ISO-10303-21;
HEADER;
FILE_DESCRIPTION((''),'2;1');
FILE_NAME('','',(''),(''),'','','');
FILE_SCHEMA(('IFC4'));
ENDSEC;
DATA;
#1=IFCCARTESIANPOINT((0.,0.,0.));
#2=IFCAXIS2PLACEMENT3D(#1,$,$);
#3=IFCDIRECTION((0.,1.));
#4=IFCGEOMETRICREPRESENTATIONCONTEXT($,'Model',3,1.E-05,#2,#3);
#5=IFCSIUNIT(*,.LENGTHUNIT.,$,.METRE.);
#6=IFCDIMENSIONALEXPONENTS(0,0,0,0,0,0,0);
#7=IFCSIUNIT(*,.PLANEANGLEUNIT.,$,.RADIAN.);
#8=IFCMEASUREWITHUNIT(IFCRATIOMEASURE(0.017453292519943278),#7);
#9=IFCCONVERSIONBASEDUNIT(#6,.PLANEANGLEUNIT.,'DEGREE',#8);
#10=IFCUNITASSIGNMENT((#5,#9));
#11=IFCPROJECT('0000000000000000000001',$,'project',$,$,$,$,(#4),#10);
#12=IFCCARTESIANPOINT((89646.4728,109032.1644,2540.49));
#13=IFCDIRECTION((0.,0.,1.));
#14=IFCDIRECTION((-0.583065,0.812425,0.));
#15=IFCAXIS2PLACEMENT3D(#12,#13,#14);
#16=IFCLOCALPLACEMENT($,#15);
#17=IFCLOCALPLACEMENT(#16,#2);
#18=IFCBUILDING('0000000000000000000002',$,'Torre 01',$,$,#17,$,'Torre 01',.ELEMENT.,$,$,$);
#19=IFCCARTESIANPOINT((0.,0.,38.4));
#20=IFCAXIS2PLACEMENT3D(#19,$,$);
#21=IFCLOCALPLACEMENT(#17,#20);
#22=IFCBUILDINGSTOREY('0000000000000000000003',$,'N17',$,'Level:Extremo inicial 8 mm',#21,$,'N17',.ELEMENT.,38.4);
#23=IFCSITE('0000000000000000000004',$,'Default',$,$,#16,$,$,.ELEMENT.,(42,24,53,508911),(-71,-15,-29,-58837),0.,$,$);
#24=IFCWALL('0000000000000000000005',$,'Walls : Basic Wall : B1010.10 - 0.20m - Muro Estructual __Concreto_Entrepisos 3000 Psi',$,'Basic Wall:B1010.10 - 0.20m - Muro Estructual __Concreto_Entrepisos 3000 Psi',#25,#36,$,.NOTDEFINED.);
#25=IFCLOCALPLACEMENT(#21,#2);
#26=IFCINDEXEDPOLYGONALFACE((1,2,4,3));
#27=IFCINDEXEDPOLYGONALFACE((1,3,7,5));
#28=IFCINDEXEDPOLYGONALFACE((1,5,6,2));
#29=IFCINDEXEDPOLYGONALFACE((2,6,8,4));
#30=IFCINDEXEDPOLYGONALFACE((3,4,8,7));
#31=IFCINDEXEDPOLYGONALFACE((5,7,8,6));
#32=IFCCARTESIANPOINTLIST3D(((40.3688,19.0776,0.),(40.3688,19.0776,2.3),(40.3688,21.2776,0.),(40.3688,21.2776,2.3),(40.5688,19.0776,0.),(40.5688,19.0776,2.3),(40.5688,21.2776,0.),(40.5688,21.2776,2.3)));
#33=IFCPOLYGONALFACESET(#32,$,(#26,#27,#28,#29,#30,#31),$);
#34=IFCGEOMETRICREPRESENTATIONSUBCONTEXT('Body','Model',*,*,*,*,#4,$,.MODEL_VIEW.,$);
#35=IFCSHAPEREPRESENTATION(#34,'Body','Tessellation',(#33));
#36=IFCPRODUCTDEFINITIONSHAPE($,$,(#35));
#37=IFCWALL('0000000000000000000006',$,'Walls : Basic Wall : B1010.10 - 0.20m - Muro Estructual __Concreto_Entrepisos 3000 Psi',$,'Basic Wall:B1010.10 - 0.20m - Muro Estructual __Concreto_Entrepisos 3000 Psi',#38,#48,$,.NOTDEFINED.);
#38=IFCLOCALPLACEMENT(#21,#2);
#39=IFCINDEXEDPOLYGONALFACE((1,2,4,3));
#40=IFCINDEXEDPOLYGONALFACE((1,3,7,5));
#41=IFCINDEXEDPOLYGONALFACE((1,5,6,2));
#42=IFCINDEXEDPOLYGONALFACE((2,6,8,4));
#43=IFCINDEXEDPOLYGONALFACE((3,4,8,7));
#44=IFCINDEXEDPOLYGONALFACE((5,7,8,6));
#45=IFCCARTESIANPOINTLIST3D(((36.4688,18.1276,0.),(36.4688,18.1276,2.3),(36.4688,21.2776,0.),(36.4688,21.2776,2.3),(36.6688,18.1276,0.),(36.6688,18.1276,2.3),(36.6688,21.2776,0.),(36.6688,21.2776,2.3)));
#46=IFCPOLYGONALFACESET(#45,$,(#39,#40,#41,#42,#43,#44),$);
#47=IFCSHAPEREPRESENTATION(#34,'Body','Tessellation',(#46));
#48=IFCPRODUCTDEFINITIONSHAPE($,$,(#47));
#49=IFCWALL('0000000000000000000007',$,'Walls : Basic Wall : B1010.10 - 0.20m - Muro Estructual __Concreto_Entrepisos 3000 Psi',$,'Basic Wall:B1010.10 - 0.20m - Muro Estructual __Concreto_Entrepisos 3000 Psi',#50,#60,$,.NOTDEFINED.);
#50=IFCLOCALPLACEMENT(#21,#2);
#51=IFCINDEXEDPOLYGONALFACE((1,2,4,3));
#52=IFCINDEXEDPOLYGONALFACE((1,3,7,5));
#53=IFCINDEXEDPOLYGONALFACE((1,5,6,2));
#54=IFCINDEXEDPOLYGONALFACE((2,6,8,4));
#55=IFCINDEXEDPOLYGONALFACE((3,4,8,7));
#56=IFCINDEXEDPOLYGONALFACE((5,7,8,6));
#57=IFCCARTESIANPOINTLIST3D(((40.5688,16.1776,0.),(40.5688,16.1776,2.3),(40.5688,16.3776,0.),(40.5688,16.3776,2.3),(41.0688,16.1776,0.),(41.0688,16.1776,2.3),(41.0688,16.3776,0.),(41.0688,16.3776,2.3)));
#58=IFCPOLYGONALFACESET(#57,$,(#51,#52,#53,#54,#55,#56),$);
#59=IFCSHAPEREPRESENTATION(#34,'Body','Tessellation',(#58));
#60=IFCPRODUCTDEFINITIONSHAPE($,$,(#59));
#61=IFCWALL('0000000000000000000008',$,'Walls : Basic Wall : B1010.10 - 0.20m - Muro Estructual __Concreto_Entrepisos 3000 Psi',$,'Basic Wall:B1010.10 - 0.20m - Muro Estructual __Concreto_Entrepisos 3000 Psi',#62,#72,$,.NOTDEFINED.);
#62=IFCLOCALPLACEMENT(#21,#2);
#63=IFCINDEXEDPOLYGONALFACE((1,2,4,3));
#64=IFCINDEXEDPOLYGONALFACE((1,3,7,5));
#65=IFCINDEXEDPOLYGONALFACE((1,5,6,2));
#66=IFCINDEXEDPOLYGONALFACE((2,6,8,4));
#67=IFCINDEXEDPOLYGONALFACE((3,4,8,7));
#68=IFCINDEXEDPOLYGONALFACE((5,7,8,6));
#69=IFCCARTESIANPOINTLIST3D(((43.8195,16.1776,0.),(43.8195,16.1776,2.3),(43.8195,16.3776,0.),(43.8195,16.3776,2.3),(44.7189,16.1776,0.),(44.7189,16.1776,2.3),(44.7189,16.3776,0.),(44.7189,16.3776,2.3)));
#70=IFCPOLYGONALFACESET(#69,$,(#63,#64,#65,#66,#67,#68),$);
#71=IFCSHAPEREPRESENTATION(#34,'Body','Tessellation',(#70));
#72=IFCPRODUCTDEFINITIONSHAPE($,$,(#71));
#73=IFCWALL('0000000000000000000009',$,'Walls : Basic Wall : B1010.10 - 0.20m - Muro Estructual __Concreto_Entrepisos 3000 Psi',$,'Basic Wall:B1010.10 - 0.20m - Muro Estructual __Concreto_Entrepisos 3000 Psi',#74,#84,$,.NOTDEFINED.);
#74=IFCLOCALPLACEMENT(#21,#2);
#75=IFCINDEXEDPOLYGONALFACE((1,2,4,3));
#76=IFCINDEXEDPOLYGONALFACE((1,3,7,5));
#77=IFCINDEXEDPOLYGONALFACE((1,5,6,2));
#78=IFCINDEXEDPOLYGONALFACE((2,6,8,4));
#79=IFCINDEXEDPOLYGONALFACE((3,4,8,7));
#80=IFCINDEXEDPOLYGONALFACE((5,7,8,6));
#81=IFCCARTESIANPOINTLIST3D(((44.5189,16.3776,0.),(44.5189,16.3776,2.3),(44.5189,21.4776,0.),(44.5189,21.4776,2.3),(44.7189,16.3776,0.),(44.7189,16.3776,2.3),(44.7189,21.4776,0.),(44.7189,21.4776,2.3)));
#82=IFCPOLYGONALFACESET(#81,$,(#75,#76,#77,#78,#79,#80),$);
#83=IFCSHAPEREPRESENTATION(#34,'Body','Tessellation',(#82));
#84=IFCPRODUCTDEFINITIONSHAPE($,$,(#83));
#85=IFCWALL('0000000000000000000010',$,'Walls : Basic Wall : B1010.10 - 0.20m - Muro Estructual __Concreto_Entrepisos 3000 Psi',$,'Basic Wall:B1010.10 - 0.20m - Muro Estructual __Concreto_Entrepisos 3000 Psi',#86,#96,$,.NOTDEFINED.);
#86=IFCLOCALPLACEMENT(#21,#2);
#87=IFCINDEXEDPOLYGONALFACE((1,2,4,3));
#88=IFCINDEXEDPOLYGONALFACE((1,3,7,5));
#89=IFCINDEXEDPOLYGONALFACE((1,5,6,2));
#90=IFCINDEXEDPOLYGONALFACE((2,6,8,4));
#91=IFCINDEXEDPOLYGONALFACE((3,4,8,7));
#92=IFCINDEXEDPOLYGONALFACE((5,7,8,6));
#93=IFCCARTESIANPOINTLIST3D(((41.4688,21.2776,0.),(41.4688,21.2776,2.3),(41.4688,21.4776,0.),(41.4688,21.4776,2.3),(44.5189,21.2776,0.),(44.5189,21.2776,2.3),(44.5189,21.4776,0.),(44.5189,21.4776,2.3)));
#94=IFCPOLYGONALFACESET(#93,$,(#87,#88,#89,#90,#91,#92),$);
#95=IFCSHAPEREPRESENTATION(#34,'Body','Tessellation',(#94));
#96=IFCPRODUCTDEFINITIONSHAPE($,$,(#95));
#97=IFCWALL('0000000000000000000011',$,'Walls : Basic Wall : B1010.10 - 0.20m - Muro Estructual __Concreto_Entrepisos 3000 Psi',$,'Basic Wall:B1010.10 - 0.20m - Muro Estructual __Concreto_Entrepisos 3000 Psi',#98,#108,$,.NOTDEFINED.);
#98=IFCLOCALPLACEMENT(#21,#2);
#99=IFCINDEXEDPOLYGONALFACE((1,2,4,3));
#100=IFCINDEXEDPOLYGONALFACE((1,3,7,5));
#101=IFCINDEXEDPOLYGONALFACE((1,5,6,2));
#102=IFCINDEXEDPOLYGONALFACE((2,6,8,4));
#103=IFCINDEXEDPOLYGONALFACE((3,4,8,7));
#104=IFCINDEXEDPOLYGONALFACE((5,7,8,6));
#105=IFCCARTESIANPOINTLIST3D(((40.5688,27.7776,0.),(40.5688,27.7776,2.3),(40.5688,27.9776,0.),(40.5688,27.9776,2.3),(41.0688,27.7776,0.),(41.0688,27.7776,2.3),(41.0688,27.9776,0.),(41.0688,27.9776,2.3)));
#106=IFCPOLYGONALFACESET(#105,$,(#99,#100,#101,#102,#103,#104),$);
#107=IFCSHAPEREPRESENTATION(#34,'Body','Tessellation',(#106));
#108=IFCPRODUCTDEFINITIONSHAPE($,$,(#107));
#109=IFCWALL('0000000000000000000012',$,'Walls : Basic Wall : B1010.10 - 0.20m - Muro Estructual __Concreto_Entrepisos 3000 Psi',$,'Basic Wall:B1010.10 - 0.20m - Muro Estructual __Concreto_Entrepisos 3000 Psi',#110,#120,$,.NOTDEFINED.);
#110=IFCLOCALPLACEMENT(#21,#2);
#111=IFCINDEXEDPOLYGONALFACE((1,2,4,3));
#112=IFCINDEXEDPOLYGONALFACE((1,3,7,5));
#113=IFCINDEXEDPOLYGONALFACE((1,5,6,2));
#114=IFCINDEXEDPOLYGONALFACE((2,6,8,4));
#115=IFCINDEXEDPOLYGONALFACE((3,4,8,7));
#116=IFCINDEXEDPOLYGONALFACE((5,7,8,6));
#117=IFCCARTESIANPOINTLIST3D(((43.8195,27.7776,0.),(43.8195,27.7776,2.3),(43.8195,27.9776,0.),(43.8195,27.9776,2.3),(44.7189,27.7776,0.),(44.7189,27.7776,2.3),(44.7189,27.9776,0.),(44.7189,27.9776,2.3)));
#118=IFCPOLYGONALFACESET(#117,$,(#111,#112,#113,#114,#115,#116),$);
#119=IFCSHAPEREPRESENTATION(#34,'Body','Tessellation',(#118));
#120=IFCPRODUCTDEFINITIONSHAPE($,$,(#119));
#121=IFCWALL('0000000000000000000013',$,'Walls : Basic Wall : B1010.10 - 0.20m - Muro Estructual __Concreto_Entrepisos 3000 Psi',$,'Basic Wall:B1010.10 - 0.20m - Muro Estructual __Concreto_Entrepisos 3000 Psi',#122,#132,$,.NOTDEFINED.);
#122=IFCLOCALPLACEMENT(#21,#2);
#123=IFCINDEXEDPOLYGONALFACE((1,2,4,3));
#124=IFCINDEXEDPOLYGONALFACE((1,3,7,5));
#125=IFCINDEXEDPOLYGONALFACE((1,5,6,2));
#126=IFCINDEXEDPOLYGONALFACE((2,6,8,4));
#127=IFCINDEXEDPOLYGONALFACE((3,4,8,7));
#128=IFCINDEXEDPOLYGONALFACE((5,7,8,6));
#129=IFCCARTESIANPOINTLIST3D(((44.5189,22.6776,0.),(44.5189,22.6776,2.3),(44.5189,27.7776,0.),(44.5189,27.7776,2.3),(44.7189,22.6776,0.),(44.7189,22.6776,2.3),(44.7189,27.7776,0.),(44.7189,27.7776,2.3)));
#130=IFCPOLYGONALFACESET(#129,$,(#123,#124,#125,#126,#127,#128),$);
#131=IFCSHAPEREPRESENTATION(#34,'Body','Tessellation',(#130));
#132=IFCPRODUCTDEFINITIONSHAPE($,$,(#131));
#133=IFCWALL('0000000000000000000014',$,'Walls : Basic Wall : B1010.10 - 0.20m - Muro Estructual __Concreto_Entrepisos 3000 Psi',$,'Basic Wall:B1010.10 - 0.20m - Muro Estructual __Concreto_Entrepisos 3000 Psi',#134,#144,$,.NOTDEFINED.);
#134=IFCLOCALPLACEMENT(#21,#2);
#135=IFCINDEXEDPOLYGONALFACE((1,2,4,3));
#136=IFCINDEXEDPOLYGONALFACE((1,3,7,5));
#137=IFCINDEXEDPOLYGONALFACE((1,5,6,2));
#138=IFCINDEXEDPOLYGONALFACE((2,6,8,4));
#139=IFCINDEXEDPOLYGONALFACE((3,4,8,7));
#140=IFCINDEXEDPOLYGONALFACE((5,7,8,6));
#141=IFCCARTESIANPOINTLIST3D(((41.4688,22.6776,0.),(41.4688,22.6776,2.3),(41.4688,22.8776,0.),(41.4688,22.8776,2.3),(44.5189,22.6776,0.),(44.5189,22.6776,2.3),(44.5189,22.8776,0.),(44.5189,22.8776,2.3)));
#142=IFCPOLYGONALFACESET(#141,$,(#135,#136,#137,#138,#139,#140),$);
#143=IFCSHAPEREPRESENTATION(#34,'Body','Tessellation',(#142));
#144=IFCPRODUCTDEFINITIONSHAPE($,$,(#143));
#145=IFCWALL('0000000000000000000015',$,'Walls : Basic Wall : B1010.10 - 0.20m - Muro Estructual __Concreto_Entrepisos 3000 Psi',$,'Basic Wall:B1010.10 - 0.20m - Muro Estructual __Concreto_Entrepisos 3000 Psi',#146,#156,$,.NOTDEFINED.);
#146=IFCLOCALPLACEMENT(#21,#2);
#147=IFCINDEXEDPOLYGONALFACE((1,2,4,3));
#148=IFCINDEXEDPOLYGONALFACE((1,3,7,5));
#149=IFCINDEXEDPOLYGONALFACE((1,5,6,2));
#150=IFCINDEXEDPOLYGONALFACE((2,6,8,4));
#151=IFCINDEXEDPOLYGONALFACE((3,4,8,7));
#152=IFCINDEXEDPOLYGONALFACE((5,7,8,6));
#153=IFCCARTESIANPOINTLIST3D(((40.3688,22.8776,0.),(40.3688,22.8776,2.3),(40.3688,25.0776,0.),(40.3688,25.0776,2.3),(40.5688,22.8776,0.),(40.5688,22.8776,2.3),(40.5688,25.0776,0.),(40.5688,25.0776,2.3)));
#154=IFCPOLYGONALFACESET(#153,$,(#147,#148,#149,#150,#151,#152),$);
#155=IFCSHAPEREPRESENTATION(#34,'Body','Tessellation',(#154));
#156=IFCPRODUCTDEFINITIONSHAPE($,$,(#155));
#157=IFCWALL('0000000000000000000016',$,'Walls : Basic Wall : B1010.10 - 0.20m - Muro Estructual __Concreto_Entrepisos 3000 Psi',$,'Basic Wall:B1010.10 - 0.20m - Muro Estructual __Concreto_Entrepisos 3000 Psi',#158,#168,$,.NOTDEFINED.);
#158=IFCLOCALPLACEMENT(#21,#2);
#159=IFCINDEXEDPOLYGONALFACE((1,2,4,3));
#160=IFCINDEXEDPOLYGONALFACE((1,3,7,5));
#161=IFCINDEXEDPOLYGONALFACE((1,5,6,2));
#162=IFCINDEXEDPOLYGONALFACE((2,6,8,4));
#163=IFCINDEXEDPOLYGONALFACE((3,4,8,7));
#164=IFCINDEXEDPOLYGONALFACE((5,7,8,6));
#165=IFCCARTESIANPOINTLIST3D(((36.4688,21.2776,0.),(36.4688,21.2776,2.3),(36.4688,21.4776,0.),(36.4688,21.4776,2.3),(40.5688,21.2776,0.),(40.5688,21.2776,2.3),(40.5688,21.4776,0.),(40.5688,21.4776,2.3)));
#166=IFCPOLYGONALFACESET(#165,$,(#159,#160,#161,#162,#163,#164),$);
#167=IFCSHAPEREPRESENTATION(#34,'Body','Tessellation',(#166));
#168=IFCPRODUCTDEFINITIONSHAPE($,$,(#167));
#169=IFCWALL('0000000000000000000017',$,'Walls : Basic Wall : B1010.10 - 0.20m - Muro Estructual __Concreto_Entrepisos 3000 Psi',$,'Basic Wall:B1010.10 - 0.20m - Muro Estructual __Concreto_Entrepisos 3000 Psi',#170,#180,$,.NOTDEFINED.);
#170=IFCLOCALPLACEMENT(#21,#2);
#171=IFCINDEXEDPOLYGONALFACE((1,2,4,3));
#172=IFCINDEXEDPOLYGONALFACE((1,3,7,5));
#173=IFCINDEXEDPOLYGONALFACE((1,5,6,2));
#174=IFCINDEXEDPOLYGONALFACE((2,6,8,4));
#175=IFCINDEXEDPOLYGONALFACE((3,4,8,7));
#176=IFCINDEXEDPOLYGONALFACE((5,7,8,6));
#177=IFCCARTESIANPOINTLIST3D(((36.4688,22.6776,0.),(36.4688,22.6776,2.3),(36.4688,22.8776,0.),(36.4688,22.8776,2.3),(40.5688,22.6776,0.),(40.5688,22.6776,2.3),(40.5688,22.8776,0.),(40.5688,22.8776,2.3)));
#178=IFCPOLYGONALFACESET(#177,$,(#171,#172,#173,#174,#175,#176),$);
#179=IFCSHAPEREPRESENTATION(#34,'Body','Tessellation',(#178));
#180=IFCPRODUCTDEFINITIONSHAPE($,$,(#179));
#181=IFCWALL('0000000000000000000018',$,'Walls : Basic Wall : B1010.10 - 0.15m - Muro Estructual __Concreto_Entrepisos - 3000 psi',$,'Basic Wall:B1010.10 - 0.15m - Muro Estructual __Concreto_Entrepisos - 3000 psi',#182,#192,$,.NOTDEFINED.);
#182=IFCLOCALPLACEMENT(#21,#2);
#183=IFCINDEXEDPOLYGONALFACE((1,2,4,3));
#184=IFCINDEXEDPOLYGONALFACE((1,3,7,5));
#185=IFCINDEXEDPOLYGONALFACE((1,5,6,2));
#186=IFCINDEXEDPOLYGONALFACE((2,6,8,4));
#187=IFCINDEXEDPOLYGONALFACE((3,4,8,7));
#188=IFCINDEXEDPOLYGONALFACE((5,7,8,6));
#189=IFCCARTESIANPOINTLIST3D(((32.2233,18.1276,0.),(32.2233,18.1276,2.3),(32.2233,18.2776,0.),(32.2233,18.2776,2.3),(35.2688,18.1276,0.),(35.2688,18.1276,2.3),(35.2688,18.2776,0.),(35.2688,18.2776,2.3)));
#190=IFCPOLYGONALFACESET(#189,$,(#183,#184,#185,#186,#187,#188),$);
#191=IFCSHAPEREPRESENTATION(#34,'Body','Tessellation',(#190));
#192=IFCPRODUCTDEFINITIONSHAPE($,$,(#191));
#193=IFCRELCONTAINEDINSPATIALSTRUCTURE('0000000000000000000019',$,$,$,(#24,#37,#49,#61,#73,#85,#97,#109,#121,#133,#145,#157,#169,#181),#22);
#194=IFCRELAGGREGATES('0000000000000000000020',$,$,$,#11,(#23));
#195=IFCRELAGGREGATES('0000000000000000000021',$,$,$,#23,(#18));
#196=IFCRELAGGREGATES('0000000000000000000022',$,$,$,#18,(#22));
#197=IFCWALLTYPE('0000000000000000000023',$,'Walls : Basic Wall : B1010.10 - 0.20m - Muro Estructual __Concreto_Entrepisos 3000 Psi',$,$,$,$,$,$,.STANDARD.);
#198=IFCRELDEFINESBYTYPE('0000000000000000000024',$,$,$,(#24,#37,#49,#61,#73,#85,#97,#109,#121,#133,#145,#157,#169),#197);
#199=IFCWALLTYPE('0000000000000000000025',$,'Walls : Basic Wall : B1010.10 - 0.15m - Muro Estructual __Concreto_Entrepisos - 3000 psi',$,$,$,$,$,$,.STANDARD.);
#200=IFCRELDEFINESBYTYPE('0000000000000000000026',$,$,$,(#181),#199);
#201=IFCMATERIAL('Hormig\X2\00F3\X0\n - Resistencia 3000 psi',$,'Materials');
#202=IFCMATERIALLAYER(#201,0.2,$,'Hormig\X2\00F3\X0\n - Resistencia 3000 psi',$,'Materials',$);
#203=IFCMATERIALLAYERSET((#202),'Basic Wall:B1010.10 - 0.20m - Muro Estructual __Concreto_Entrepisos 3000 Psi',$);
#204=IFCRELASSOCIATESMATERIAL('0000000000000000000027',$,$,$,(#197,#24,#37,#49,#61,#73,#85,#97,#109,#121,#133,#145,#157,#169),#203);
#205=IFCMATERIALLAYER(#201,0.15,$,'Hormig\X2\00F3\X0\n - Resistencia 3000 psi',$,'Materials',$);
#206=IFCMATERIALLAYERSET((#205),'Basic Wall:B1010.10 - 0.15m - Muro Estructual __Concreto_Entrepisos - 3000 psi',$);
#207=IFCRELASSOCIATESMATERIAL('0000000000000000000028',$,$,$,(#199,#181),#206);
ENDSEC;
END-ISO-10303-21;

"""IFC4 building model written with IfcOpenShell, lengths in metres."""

from ifc_helpers import new_model, entity, si_unit, converted_unit, direction, frame, frame_2d, origin, place, context, subcontext, project, spatial, rectangle, extrude, material, layer, layer_set, layer_usage, type_object, element, save


model = new_model("IFC4")

# Units and contexts
model_context = context("Model", 3, precision=1e-05, world=origin(), true_north=direction((0.0, 1.0)))
body_context = subcontext(model_context, "Body", "Model", "MODEL_VIEW")
ifc_project = project(units=[si_unit("LENGTHUNIT", "METRE"), converted_unit("PLANEANGLEUNIT", "DEGREE", entity("IfcRatioMeasure", 0.017453292519943278), si_unit("PLANEANGLEUNIT", "RADIAN"), dimensions=[0, 0, 0, 0, 0, 0, 0])], contexts=[model_context])

# Site, building, storey
site_placement = place(None, frame((89646.4728, 109032.1644, 2540.49), z_axis=(0.0, 0.0, 1.0), x_axis=(-0.583065, 0.812425, 0.0)))
site = spatial("IfcSite", under=ifc_project, at=site_placement, Name="Default", CompositionType="ELEMENT", RefLatitude=(42, 24, 53, 508911), RefLongitude=(-71, -15, -29, -58837), RefElevation=0.0)
building_placement = place(site_placement, origin())
building = spatial("IfcBuilding", under=site, at=building_placement, Name="Torre 01", LongName="Torre 01", CompositionType="ELEMENT")
storey_placement = place(building_placement, frame((0.0, 0.0, 38.4)))
storey = spatial("IfcBuildingStorey", under=building, at=storey_placement, Name="N17", ObjectType="Level:Extremo inicial 8 mm", LongName="N17", CompositionType="ELEMENT", Elevation=38.4)

# Walls
ifc_material = material(Name="Hormigón - Resistencia 3000 psi", Category="Materials")
ifc_layer_1 = layer(ifc_material, 0.2, Name="Hormigón - Resistencia 3000 psi", Category="Materials")
ifc_layer_set_1 = layer_set([ifc_layer_1], Name="Basic Wall:B1010.10 - 0.20m - Muro Estructual __Concreto_Entrepisos 3000 Psi")
ifc_layer_usage_1 = layer_usage(ifc_layer_set_1, "AXIS2", "NEGATIVE", 0.1)
wall_type_1 = type_object("IfcWallType", Name="Walls : Basic Wall : B1010.10 - 0.20m - Muro Estructual __Concreto_Entrepisos 3000 Psi", PredefinedType="STANDARD", material=ifc_layer_set_1)
wall_1_placement = place(storey_placement, frame((40.4688, 21.2776, 0.0), z_axis=(0.0, 0.0, 1.0), x_axis=(0.0, -1.0, 0.0)))
element("IfcWall", 1, at=wall_1_placement, inside=storey, type_object=wall_type_1, material=ifc_layer_usage_1, Name="Walls : Basic Wall : B1010.10 - 0.20m - Muro Estructual __Concreto_Entrepisos 3000 Psi", ObjectType="Basic Wall:B1010.10 - 0.20m - Muro Estructual __Concreto_Entrepisos 3000 Psi", PredefinedType="NOTDEFINED", context=body_context, shape_type="SweptSolid", body=[
    extrude(rectangle(XDim=2.2, YDim=0.2, at=frame_2d((1.1, 0.0), x_axis=(-1.0, 0.0))), origin(), (0.0, 0.0, 1.0), 2.3),
])
ifc_layer_usage_2 = layer_usage(ifc_layer_set_1, "AXIS2", "NEGATIVE", 0.1)
wall_2_placement = place(storey_placement, frame((36.5688, 18.1276, 0.0), z_axis=(0.0, 0.0, 1.0), x_axis=(0.0, 1.0, 0.0)))
element("IfcWall", 2, at=wall_2_placement, inside=storey, type_object=wall_type_1, material=ifc_layer_usage_2, Name="Walls : Basic Wall : B1010.10 - 0.20m - Muro Estructual __Concreto_Entrepisos 3000 Psi", ObjectType="Basic Wall:B1010.10 - 0.20m - Muro Estructual __Concreto_Entrepisos 3000 Psi", PredefinedType="NOTDEFINED", context=body_context, shape_type="SweptSolid", body=[
    extrude(rectangle(XDim=3.15, YDim=0.2, at=frame_2d((1.575, 0.0), x_axis=(-1.0, 0.0))), origin(), (0.0, 0.0, 1.0), 2.3),
])
ifc_layer_usage_3 = layer_usage(ifc_layer_set_1, "AXIS2", "NEGATIVE", 0.1)
wall_3_placement = place(storey_placement, frame((41.0688, 16.2776, 0.0), z_axis=(0.0, 0.0, 1.0), x_axis=(-1.0, 0.0, 0.0)))
element("IfcWall", 3, at=wall_3_placement, inside=storey, type_object=wall_type_1, material=ifc_layer_usage_3, Name="Walls : Basic Wall : B1010.10 - 0.20m - Muro Estructual __Concreto_Entrepisos 3000 Psi", ObjectType="Basic Wall:B1010.10 - 0.20m - Muro Estructual __Concreto_Entrepisos 3000 Psi", PredefinedType="NOTDEFINED", context=body_context, shape_type="SweptSolid", body=[
    extrude(rectangle(XDim=0.5, YDim=0.2, at=frame_2d((0.25, 0.0), x_axis=(-1.0, 0.0))), origin(), (0.0, 0.0, 1.0), 2.3),
])
ifc_layer_usage_4 = layer_usage(ifc_layer_set_1, "AXIS2", "NEGATIVE", 0.1)
wall_4_placement = place(storey_placement, frame((43.8195, 16.2776, 0.0)))
element("IfcWall", 4, at=wall_4_placement, inside=storey, type_object=wall_type_1, material=ifc_layer_usage_4, Name="Walls : Basic Wall : B1010.10 - 0.20m - Muro Estructual __Concreto_Entrepisos 3000 Psi", ObjectType="Basic Wall:B1010.10 - 0.20m - Muro Estructual __Concreto_Entrepisos 3000 Psi", PredefinedType="NOTDEFINED", context=body_context, shape_type="SweptSolid", body=[
    extrude(rectangle(XDim=0.8993, YDim=0.2, at=frame_2d((0.4497, 0.0), x_axis=(-1.0, 0.0))), origin(), (0.0, 0.0, 1.0), 2.3),
])
ifc_layer_usage_5 = layer_usage(ifc_layer_set_1, "AXIS2", "NEGATIVE", 0.1)
wall_5_placement = place(storey_placement, frame((44.6189, 21.4776, 0.0), z_axis=(0.0, 0.0, 1.0), x_axis=(0.0, -1.0, 0.0)))
element("IfcWall", 5, at=wall_5_placement, inside=storey, type_object=wall_type_1, material=ifc_layer_usage_5, Name="Walls : Basic Wall : B1010.10 - 0.20m - Muro Estructual __Concreto_Entrepisos 3000 Psi", ObjectType="Basic Wall:B1010.10 - 0.20m - Muro Estructual __Concreto_Entrepisos 3000 Psi", PredefinedType="NOTDEFINED", context=body_context, shape_type="SweptSolid", body=[
    extrude(rectangle(XDim=5.1, YDim=0.2, at=frame_2d((2.55, 0.0), x_axis=(-1.0, 0.0))), origin(), (0.0, 0.0, 1.0), 2.3),
])
ifc_layer_usage_6 = layer_usage(ifc_layer_set_1, "AXIS2", "NEGATIVE", 0.1)
wall_6_placement = place(storey_placement, frame((41.4688, 21.3776, 0.0)))
element("IfcWall", 6, at=wall_6_placement, inside=storey, type_object=wall_type_1, material=ifc_layer_usage_6, Name="Walls : Basic Wall : B1010.10 - 0.20m - Muro Estructual __Concreto_Entrepisos 3000 Psi", ObjectType="Basic Wall:B1010.10 - 0.20m - Muro Estructual __Concreto_Entrepisos 3000 Psi", PredefinedType="NOTDEFINED", context=body_context, shape_type="SweptSolid", body=[
    extrude(rectangle(XDim=3.05, YDim=0.2, at=frame_2d((1.525, 0.0), x_axis=(-1.0, 0.0))), origin(), (0.0, 0.0, 1.0), 2.3),
])
ifc_layer_usage_7 = layer_usage(ifc_layer_set_1, "AXIS2", "POSITIVE", -0.1)
wall_7_placement = place(storey_placement, frame((41.0688, 27.8776, 0.0), z_axis=(0.0, 0.0, 1.0), x_axis=(-1.0, 0.0, 0.0)))
element("IfcWall", 7, at=wall_7_placement, inside=storey, type_object=wall_type_1, material=ifc_layer_usage_7, Name="Walls : Basic Wall : B1010.10 - 0.20m - Muro Estructual __Concreto_Entrepisos 3000 Psi", ObjectType="Basic Wall:B1010.10 - 0.20m - Muro Estructual __Concreto_Entrepisos 3000 Psi", PredefinedType="NOTDEFINED", context=body_context, shape_type="SweptSolid", body=[
    extrude(rectangle(XDim=0.5, YDim=0.2, at=frame_2d((0.25, 0.0), x_axis=(-1.0, 0.0))), origin(), (0.0, 0.0, 1.0), 2.3),
])
ifc_layer_usage_8 = layer_usage(ifc_layer_set_1, "AXIS2", "POSITIVE", -0.1)
wall_8_placement = place(storey_placement, frame((43.8195, 27.8776, 0.0)))
element("IfcWall", 8, at=wall_8_placement, inside=storey, type_object=wall_type_1, material=ifc_layer_usage_8, Name="Walls : Basic Wall : B1010.10 - 0.20m - Muro Estructual __Concreto_Entrepisos 3000 Psi", ObjectType="Basic Wall:B1010.10 - 0.20m - Muro Estructual __Concreto_Entrepisos 3000 Psi", PredefinedType="NOTDEFINED", context=body_context, shape_type="SweptSolid", body=[
    extrude(rectangle(XDim=0.8993, YDim=0.2, at=frame_2d((0.4497, 0.0), x_axis=(-1.0, 0.0))), origin(), (0.0, 0.0, 1.0), 2.3),
])
ifc_layer_usage_9 = layer_usage(ifc_layer_set_1, "AXIS2", "POSITIVE", -0.1)
wall_9_placement = place(storey_placement, frame((44.6189, 22.6776, 0.0), z_axis=(0.0, 0.0, 1.0), x_axis=(0.0, 1.0, 0.0)))
element("IfcWall", 9, at=wall_9_placement, inside=storey, type_object=wall_type_1, material=ifc_layer_usage_9, Name="Walls : Basic Wall : B1010.10 - 0.20m - Muro Estructual __Concreto_Entrepisos 3000 Psi", ObjectType="Basic Wall:B1010.10 - 0.20m - Muro Estructual __Concreto_Entrepisos 3000 Psi", PredefinedType="NOTDEFINED", context=body_context, shape_type="SweptSolid", body=[
    extrude(rectangle(XDim=5.1, YDim=0.2, at=frame_2d((2.55, 0.0), x_axis=(-1.0, 0.0))), origin(), (0.0, 0.0, 1.0), 2.3),
])
ifc_layer_usage_10 = layer_usage(ifc_layer_set_1, "AXIS2", "POSITIVE", -0.1)
wall_10_placement = place(storey_placement, frame((41.4688, 22.7776, 0.0)))
element("IfcWall", 10, at=wall_10_placement, inside=storey, type_object=wall_type_1, material=ifc_layer_usage_10, Name="Walls : Basic Wall : B1010.10 - 0.20m - Muro Estructual __Concreto_Entrepisos 3000 Psi", ObjectType="Basic Wall:B1010.10 - 0.20m - Muro Estructual __Concreto_Entrepisos 3000 Psi", PredefinedType="NOTDEFINED", context=body_context, shape_type="SweptSolid", body=[
    extrude(rectangle(XDim=3.05, YDim=0.2, at=frame_2d((1.525, 0.0), x_axis=(-1.0, 0.0))), origin(), (0.0, 0.0, 1.0), 2.3),
])
ifc_layer_usage_11 = layer_usage(ifc_layer_set_1, "AXIS2", "POSITIVE", -0.1)
wall_11_placement = place(storey_placement, frame((40.4688, 22.8776, 0.0), z_axis=(0.0, 0.0, 1.0), x_axis=(0.0, 1.0, 0.0)))
element("IfcWall", 11, at=wall_11_placement, inside=storey, type_object=wall_type_1, material=ifc_layer_usage_11, Name="Walls : Basic Wall : B1010.10 - 0.20m - Muro Estructual __Concreto_Entrepisos 3000 Psi", ObjectType="Basic Wall:B1010.10 - 0.20m - Muro Estructual __Concreto_Entrepisos 3000 Psi", PredefinedType="NOTDEFINED", context=body_context, shape_type="SweptSolid", body=[
    extrude(rectangle(XDim=2.2, YDim=0.2, at=frame_2d((1.1, 0.0), x_axis=(-1.0, 0.0))), origin(), (0.0, 0.0, 1.0), 2.3),
])
ifc_layer_usage_12 = layer_usage(ifc_layer_set_1, "AXIS2", "NEGATIVE", 0.1)
wall_12_placement = place(storey_placement, frame((36.4688, 21.3776, 0.0)))
element("IfcWall", 12, at=wall_12_placement, inside=storey, type_object=wall_type_1, material=ifc_layer_usage_12, Name="Walls : Basic Wall : B1010.10 - 0.20m - Muro Estructual __Concreto_Entrepisos 3000 Psi", ObjectType="Basic Wall:B1010.10 - 0.20m - Muro Estructual __Concreto_Entrepisos 3000 Psi", PredefinedType="NOTDEFINED", context=body_context, shape_type="SweptSolid", body=[
    extrude(rectangle(XDim=4.1, YDim=0.2, at=frame_2d((2.05, 0.0), x_axis=(-1.0, 0.0))), origin(), (0.0, 0.0, 1.0), 2.3),
])
ifc_layer_usage_13 = layer_usage(ifc_layer_set_1, "AXIS2", "POSITIVE", -0.1)
wall_13_placement = place(storey_placement, frame((36.4688, 22.7776, 0.0)))
element("IfcWall", 13, at=wall_13_placement, inside=storey, type_object=wall_type_1, material=ifc_layer_usage_13, Name="Walls : Basic Wall : B1010.10 - 0.20m - Muro Estructual __Concreto_Entrepisos 3000 Psi", ObjectType="Basic Wall:B1010.10 - 0.20m - Muro Estructual __Concreto_Entrepisos 3000 Psi", PredefinedType="NOTDEFINED", context=body_context, shape_type="SweptSolid", body=[
    extrude(rectangle(XDim=4.1, YDim=0.2, at=frame_2d((2.05, 0.0), x_axis=(-1.0, 0.0))), origin(), (0.0, 0.0, 1.0), 2.3),
])
ifc_layer_2 = layer(ifc_material, 0.15, Name="Hormigón - Resistencia 3000 psi", Category="Materials")
ifc_layer_set_2 = layer_set([ifc_layer_2], Name="Basic Wall:B1010.10 - 0.15m - Muro Estructual __Concreto_Entrepisos - 3000 psi")
ifc_layer_usage_14 = layer_usage(ifc_layer_set_2, "AXIS2", "NEGATIVE", 0.075)
wall_type_2 = type_object("IfcWallType", Name="Walls : Basic Wall : B1010.10 - 0.15m - Muro Estructual __Concreto_Entrepisos - 3000 psi", PredefinedType="STANDARD", material=ifc_layer_set_2)
wall_14_placement = place(storey_placement, frame((32.2233, 18.2026, 0.0)))
element("IfcWall", 14, at=wall_14_placement, inside=storey, type_object=wall_type_2, material=ifc_layer_usage_14, Name="Walls : Basic Wall : B1010.10 - 0.15m - Muro Estructual __Concreto_Entrepisos - 3000 psi", ObjectType="Basic Wall:B1010.10 - 0.15m - Muro Estructual __Concreto_Entrepisos - 3000 psi", PredefinedType="NOTDEFINED", context=body_context, shape_type="SweptSolid", body=[
    extrude(rectangle(XDim=3.0455, YDim=0.15, at=frame_2d((1.5228, 0.0), x_axis=(-1.0, 0.0))), origin(), (0.0, 0.0, 1.0), 2.3),
])

save(model, "model.ifc")
